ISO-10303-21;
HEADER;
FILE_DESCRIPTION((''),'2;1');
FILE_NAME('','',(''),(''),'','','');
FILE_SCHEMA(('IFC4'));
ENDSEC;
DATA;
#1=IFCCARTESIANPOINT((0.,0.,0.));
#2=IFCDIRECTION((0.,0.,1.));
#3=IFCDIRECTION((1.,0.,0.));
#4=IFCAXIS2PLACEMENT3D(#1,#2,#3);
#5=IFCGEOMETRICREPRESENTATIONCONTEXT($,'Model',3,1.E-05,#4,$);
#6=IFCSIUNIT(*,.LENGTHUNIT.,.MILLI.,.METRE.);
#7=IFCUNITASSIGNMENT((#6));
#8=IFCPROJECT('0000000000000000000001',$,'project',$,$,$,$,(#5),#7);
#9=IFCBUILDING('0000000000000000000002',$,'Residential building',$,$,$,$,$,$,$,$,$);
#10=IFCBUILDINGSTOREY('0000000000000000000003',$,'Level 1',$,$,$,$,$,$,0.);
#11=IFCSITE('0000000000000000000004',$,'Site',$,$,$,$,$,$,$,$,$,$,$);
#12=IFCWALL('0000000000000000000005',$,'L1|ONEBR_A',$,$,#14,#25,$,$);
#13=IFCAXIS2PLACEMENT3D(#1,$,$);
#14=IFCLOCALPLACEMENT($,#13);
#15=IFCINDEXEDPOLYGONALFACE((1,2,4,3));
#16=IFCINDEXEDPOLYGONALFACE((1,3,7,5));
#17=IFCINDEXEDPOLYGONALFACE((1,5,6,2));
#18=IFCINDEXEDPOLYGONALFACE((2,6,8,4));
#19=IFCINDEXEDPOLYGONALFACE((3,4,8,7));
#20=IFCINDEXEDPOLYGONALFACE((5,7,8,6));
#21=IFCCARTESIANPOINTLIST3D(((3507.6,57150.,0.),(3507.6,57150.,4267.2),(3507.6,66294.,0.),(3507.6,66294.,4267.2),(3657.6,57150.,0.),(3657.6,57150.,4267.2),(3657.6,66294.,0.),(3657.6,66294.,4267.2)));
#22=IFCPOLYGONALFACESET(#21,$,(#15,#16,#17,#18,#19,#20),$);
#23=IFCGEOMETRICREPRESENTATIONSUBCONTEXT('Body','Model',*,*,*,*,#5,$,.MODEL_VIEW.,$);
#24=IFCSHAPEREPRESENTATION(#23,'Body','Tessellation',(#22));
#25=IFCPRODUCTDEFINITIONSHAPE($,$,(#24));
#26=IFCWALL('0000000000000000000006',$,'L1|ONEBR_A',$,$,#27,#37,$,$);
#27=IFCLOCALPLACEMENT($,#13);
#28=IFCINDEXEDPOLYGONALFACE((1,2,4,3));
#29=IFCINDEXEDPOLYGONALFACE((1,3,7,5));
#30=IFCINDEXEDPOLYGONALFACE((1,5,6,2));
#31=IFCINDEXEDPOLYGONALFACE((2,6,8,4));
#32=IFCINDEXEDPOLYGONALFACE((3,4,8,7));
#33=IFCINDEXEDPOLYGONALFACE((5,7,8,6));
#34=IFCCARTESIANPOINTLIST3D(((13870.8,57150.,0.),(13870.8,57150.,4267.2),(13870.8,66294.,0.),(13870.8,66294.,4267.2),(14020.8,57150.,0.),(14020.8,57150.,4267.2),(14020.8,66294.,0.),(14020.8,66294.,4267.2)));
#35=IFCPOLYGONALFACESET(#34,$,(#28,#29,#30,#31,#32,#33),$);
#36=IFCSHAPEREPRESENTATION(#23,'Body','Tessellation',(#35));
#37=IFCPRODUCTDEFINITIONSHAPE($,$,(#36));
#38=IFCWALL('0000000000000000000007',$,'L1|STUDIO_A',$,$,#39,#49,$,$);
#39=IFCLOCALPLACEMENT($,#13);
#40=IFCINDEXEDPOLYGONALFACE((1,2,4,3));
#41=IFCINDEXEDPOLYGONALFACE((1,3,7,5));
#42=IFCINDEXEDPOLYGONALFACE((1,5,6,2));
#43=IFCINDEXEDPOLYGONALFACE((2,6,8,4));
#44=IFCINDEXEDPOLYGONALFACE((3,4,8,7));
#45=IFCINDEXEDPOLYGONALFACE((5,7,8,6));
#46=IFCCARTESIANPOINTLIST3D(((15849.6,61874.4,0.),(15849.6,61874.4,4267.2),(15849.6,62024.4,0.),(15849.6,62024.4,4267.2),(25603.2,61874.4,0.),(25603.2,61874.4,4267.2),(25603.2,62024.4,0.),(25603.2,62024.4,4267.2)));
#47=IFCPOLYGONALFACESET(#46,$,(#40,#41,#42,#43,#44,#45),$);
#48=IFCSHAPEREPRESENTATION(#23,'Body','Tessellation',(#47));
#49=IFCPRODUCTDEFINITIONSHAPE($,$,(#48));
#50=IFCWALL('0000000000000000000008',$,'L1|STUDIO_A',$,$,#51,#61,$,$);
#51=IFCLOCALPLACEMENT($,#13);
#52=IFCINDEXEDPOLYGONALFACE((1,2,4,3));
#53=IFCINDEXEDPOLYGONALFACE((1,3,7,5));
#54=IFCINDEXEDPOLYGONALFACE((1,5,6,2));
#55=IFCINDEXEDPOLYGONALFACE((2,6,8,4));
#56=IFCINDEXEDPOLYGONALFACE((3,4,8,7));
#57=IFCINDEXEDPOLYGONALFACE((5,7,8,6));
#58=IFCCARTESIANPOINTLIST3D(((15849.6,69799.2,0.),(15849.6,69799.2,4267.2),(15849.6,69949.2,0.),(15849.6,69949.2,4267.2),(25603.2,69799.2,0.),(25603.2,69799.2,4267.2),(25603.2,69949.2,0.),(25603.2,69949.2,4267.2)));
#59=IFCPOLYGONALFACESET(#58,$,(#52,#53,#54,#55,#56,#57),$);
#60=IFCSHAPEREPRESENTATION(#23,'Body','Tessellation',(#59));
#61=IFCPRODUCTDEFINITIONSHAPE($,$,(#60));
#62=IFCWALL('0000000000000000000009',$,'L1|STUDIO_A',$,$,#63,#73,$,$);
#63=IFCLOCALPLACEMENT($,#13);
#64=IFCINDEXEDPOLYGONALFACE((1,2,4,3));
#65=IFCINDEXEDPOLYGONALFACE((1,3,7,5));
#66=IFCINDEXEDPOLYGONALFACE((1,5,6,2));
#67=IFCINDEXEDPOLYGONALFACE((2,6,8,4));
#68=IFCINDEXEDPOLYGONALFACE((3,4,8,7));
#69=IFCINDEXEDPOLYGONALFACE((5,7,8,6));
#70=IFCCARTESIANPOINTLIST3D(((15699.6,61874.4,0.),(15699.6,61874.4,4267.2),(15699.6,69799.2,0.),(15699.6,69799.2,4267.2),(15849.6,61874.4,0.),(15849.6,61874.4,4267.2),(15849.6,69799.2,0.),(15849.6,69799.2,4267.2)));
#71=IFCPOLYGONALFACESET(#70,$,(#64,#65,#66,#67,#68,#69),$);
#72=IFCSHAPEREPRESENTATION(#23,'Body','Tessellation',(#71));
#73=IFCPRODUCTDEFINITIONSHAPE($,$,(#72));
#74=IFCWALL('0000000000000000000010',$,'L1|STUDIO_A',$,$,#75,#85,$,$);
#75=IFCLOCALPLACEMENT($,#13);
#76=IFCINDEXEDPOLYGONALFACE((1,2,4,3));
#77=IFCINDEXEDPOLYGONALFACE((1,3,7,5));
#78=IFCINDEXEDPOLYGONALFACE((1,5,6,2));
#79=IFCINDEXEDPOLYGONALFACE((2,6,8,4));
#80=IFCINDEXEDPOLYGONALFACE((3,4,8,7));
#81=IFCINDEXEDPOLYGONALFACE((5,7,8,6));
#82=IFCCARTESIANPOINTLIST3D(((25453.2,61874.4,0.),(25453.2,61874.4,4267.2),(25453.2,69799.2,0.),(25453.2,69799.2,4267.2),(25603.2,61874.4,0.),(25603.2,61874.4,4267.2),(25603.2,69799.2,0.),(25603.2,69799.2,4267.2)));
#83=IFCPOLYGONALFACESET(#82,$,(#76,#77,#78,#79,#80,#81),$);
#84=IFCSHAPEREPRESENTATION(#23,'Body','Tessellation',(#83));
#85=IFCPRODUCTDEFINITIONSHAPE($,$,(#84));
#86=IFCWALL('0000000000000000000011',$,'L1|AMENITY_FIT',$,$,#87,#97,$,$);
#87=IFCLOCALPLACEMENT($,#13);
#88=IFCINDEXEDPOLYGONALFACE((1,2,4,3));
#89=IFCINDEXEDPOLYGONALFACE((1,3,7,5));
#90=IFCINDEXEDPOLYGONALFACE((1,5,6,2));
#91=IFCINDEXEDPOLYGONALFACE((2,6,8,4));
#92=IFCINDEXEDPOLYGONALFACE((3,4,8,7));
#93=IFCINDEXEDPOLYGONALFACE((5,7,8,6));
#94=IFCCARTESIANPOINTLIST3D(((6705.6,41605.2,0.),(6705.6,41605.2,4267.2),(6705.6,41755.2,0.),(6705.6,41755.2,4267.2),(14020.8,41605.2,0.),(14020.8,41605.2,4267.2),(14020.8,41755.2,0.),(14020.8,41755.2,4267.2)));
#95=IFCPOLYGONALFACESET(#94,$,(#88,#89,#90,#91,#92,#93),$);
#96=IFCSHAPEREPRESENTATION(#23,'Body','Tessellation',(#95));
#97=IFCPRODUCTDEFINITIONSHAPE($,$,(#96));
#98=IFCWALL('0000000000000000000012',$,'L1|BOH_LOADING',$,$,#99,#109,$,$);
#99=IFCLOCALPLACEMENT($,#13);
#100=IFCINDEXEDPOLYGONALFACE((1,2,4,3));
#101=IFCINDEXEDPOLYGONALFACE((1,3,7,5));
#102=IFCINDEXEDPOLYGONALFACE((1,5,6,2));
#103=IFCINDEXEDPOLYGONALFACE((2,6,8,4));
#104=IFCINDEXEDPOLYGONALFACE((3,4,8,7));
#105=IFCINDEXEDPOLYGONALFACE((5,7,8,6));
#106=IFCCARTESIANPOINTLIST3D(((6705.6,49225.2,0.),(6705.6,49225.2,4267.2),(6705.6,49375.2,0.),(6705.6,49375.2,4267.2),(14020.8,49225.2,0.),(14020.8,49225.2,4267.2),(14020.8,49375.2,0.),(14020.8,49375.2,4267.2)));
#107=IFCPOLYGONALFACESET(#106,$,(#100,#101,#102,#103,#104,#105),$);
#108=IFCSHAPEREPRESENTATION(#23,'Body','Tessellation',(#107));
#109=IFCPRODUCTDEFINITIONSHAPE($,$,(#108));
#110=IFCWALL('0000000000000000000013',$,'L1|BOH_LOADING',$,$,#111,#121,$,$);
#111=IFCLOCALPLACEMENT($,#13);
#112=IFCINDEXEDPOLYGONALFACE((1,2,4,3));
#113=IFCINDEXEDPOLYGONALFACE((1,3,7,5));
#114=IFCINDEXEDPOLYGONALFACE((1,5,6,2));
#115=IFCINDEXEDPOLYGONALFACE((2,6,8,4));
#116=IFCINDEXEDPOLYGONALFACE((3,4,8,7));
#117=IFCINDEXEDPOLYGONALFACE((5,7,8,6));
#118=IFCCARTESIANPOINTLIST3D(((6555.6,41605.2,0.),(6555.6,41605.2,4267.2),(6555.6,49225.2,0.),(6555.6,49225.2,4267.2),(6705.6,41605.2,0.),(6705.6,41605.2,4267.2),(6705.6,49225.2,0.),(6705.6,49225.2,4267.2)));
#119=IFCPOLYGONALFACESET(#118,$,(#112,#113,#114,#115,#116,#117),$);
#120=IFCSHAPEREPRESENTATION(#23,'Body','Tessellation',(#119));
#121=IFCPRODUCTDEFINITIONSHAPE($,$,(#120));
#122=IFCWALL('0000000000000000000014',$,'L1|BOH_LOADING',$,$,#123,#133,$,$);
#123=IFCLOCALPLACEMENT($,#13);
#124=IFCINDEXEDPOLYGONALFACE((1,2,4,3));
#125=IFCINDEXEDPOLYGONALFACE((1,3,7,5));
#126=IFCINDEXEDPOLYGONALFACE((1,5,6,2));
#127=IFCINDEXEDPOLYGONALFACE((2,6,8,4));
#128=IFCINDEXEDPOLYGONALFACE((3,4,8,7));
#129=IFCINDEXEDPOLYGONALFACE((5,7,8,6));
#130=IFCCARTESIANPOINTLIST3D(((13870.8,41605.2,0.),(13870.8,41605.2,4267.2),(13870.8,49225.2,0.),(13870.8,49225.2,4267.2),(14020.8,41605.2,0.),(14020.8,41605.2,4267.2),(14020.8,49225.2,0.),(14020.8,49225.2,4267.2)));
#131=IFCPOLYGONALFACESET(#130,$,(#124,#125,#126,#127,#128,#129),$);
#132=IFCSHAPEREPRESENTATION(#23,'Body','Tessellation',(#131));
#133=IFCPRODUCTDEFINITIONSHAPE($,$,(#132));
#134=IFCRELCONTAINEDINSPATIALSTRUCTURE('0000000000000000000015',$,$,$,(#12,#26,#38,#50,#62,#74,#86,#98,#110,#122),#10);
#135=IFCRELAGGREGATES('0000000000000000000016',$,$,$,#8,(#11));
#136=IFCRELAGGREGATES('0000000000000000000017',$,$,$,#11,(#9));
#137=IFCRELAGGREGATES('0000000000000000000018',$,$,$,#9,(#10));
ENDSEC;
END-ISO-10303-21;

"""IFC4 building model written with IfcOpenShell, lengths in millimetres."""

from ifc_helpers import new_model, si_unit, frame, origin_with_axes, place, context, subcontext, project, spatial, indexed_curve, outline, extrude, element, save


model = new_model("IFC4")

# Units and contexts
model_context = context("Model", 3, precision=1e-05, world=origin_with_axes())
body_context = subcontext(model_context, "Body", "Model", "MODEL_VIEW")
ifc_project = project(units=[si_unit("LENGTHUNIT", "METRE", prefix="MILLI")], contexts=[model_context])

# Site, building, storey
site = spatial("IfcSite", under=ifc_project, Name="Site")
building = spatial("IfcBuilding", under=site, Name="Residential building")
storey = spatial("IfcBuildingStorey", under=building, Name="Level 1", Elevation=0.0)

# Walls
for number, where, z_axis, x_axis, name in (
    (1, (3657.6, 57150.0, 0.0), (0.0, 0.0, 1.0), (0.0, 1.0, 0.0), "L1|ONEBR_A"),
    (2, (14020.8, 57150.0, 0.0), (0.0, 0.0, 1.0), (0.0, 1.0, 0.0), "L1|ONEBR_A"),
):
    element("IfcWall", number, at=place(None, frame(where, z_axis=z_axis, x_axis=x_axis)), inside=storey, Name=name, context=body_context, shape_type="SweptSolid", body=[
        extrude(outline(indexed_curve([(0.0, 0.0), (0.0, 150.0), (9144.0, 150.0), (9144.0, 0.0), (0.0, 0.0)], self_intersect=False)), origin_with_axes(), (0.0, 0.0, 1.0), 4267.2),
    ])
for number, where, z_axis, x_axis, name in (
    (3, (15849.6, 61874.4, 0.0), (0.0, 0.0, 1.0), (1.0, 0.0, 0.0), "L1|STUDIO_A"),
    (4, (15849.6, 69799.2, 0.0), (0.0, 0.0, 1.0), (1.0, 0.0, 0.0), "L1|STUDIO_A"),
):
    element("IfcWall", number, at=place(None, frame(where, z_axis=z_axis, x_axis=x_axis)), inside=storey, Name=name, context=body_context, shape_type="SweptSolid", body=[
        extrude(outline(indexed_curve([(0.0, 0.0), (0.0, 150.0), (9753.6, 150.0), (9753.6, 0.0), (0.0, 0.0)], self_intersect=False)), origin_with_axes(), (0.0, 0.0, 1.0), 4267.2),
    ])
for number, where, z_axis, x_axis, name in (
    (5, (15849.6, 61874.4, 0.0), (0.0, 0.0, 1.0), (0.0, 1.0, 0.0), "L1|STUDIO_A"),
    (6, (25603.2, 61874.4, 0.0), (0.0, 0.0, 1.0), (0.0, 1.0, 0.0), "L1|STUDIO_A"),
):
    element("IfcWall", number, at=place(None, frame(where, z_axis=z_axis, x_axis=x_axis)), inside=storey, Name=name, context=body_context, shape_type="SweptSolid", body=[
        extrude(outline(indexed_curve([(0.0, 0.0), (0.0, 150.0), (7924.8, 150.0), (7924.8, 0.0), (0.0, 0.0)], self_intersect=False)), origin_with_axes(), (0.0, 0.0, 1.0), 4267.2),
    ])
for number, where, z_axis, x_axis, name in (
    (7, (6705.6, 41605.2, 0.0), (0.0, 0.0, 1.0), (1.0, 0.0, 0.0), "L1|AMENITY_FIT"),
    (8, (6705.6, 49225.2, 0.0), (0.0, 0.0, 1.0), (1.0, 0.0, 0.0), "L1|BOH_LOADING"),
):
    element("IfcWall", number, at=place(None, frame(where, z_axis=z_axis, x_axis=x_axis)), inside=storey, Name=name, context=body_context, shape_type="SweptSolid", body=[
        extrude(outline(indexed_curve([(0.0, 0.0), (0.0, 150.0), (7315.2, 150.0), (7315.2, 0.0), (0.0, 0.0)], self_intersect=False)), origin_with_axes(), (0.0, 0.0, 1.0), 4267.2),
    ])
for number, where, z_axis, x_axis, name in (
    (9, (6705.6, 41605.2, 0.0), (0.0, 0.0, 1.0), (0.0, 1.0, 0.0), "L1|BOH_LOADING"),
    (10, (14020.8, 41605.2, 0.0), (0.0, 0.0, 1.0), (0.0, 1.0, 0.0), "L1|BOH_LOADING"),
):
    element("IfcWall", number, at=place(None, frame(where, z_axis=z_axis, x_axis=x_axis)), inside=storey, Name=name, context=body_context, shape_type="SweptSolid", body=[
        extrude(outline(indexed_curve([(0.0, 0.0), (0.0, 150.0), (7620.0, 150.0), (7620.0, 0.0), (0.0, 0.0)], self_intersect=False)), origin_with_axes(), (0.0, 0.0, 1.0), 4267.2),
    ])

save(model, "model.ifc")
